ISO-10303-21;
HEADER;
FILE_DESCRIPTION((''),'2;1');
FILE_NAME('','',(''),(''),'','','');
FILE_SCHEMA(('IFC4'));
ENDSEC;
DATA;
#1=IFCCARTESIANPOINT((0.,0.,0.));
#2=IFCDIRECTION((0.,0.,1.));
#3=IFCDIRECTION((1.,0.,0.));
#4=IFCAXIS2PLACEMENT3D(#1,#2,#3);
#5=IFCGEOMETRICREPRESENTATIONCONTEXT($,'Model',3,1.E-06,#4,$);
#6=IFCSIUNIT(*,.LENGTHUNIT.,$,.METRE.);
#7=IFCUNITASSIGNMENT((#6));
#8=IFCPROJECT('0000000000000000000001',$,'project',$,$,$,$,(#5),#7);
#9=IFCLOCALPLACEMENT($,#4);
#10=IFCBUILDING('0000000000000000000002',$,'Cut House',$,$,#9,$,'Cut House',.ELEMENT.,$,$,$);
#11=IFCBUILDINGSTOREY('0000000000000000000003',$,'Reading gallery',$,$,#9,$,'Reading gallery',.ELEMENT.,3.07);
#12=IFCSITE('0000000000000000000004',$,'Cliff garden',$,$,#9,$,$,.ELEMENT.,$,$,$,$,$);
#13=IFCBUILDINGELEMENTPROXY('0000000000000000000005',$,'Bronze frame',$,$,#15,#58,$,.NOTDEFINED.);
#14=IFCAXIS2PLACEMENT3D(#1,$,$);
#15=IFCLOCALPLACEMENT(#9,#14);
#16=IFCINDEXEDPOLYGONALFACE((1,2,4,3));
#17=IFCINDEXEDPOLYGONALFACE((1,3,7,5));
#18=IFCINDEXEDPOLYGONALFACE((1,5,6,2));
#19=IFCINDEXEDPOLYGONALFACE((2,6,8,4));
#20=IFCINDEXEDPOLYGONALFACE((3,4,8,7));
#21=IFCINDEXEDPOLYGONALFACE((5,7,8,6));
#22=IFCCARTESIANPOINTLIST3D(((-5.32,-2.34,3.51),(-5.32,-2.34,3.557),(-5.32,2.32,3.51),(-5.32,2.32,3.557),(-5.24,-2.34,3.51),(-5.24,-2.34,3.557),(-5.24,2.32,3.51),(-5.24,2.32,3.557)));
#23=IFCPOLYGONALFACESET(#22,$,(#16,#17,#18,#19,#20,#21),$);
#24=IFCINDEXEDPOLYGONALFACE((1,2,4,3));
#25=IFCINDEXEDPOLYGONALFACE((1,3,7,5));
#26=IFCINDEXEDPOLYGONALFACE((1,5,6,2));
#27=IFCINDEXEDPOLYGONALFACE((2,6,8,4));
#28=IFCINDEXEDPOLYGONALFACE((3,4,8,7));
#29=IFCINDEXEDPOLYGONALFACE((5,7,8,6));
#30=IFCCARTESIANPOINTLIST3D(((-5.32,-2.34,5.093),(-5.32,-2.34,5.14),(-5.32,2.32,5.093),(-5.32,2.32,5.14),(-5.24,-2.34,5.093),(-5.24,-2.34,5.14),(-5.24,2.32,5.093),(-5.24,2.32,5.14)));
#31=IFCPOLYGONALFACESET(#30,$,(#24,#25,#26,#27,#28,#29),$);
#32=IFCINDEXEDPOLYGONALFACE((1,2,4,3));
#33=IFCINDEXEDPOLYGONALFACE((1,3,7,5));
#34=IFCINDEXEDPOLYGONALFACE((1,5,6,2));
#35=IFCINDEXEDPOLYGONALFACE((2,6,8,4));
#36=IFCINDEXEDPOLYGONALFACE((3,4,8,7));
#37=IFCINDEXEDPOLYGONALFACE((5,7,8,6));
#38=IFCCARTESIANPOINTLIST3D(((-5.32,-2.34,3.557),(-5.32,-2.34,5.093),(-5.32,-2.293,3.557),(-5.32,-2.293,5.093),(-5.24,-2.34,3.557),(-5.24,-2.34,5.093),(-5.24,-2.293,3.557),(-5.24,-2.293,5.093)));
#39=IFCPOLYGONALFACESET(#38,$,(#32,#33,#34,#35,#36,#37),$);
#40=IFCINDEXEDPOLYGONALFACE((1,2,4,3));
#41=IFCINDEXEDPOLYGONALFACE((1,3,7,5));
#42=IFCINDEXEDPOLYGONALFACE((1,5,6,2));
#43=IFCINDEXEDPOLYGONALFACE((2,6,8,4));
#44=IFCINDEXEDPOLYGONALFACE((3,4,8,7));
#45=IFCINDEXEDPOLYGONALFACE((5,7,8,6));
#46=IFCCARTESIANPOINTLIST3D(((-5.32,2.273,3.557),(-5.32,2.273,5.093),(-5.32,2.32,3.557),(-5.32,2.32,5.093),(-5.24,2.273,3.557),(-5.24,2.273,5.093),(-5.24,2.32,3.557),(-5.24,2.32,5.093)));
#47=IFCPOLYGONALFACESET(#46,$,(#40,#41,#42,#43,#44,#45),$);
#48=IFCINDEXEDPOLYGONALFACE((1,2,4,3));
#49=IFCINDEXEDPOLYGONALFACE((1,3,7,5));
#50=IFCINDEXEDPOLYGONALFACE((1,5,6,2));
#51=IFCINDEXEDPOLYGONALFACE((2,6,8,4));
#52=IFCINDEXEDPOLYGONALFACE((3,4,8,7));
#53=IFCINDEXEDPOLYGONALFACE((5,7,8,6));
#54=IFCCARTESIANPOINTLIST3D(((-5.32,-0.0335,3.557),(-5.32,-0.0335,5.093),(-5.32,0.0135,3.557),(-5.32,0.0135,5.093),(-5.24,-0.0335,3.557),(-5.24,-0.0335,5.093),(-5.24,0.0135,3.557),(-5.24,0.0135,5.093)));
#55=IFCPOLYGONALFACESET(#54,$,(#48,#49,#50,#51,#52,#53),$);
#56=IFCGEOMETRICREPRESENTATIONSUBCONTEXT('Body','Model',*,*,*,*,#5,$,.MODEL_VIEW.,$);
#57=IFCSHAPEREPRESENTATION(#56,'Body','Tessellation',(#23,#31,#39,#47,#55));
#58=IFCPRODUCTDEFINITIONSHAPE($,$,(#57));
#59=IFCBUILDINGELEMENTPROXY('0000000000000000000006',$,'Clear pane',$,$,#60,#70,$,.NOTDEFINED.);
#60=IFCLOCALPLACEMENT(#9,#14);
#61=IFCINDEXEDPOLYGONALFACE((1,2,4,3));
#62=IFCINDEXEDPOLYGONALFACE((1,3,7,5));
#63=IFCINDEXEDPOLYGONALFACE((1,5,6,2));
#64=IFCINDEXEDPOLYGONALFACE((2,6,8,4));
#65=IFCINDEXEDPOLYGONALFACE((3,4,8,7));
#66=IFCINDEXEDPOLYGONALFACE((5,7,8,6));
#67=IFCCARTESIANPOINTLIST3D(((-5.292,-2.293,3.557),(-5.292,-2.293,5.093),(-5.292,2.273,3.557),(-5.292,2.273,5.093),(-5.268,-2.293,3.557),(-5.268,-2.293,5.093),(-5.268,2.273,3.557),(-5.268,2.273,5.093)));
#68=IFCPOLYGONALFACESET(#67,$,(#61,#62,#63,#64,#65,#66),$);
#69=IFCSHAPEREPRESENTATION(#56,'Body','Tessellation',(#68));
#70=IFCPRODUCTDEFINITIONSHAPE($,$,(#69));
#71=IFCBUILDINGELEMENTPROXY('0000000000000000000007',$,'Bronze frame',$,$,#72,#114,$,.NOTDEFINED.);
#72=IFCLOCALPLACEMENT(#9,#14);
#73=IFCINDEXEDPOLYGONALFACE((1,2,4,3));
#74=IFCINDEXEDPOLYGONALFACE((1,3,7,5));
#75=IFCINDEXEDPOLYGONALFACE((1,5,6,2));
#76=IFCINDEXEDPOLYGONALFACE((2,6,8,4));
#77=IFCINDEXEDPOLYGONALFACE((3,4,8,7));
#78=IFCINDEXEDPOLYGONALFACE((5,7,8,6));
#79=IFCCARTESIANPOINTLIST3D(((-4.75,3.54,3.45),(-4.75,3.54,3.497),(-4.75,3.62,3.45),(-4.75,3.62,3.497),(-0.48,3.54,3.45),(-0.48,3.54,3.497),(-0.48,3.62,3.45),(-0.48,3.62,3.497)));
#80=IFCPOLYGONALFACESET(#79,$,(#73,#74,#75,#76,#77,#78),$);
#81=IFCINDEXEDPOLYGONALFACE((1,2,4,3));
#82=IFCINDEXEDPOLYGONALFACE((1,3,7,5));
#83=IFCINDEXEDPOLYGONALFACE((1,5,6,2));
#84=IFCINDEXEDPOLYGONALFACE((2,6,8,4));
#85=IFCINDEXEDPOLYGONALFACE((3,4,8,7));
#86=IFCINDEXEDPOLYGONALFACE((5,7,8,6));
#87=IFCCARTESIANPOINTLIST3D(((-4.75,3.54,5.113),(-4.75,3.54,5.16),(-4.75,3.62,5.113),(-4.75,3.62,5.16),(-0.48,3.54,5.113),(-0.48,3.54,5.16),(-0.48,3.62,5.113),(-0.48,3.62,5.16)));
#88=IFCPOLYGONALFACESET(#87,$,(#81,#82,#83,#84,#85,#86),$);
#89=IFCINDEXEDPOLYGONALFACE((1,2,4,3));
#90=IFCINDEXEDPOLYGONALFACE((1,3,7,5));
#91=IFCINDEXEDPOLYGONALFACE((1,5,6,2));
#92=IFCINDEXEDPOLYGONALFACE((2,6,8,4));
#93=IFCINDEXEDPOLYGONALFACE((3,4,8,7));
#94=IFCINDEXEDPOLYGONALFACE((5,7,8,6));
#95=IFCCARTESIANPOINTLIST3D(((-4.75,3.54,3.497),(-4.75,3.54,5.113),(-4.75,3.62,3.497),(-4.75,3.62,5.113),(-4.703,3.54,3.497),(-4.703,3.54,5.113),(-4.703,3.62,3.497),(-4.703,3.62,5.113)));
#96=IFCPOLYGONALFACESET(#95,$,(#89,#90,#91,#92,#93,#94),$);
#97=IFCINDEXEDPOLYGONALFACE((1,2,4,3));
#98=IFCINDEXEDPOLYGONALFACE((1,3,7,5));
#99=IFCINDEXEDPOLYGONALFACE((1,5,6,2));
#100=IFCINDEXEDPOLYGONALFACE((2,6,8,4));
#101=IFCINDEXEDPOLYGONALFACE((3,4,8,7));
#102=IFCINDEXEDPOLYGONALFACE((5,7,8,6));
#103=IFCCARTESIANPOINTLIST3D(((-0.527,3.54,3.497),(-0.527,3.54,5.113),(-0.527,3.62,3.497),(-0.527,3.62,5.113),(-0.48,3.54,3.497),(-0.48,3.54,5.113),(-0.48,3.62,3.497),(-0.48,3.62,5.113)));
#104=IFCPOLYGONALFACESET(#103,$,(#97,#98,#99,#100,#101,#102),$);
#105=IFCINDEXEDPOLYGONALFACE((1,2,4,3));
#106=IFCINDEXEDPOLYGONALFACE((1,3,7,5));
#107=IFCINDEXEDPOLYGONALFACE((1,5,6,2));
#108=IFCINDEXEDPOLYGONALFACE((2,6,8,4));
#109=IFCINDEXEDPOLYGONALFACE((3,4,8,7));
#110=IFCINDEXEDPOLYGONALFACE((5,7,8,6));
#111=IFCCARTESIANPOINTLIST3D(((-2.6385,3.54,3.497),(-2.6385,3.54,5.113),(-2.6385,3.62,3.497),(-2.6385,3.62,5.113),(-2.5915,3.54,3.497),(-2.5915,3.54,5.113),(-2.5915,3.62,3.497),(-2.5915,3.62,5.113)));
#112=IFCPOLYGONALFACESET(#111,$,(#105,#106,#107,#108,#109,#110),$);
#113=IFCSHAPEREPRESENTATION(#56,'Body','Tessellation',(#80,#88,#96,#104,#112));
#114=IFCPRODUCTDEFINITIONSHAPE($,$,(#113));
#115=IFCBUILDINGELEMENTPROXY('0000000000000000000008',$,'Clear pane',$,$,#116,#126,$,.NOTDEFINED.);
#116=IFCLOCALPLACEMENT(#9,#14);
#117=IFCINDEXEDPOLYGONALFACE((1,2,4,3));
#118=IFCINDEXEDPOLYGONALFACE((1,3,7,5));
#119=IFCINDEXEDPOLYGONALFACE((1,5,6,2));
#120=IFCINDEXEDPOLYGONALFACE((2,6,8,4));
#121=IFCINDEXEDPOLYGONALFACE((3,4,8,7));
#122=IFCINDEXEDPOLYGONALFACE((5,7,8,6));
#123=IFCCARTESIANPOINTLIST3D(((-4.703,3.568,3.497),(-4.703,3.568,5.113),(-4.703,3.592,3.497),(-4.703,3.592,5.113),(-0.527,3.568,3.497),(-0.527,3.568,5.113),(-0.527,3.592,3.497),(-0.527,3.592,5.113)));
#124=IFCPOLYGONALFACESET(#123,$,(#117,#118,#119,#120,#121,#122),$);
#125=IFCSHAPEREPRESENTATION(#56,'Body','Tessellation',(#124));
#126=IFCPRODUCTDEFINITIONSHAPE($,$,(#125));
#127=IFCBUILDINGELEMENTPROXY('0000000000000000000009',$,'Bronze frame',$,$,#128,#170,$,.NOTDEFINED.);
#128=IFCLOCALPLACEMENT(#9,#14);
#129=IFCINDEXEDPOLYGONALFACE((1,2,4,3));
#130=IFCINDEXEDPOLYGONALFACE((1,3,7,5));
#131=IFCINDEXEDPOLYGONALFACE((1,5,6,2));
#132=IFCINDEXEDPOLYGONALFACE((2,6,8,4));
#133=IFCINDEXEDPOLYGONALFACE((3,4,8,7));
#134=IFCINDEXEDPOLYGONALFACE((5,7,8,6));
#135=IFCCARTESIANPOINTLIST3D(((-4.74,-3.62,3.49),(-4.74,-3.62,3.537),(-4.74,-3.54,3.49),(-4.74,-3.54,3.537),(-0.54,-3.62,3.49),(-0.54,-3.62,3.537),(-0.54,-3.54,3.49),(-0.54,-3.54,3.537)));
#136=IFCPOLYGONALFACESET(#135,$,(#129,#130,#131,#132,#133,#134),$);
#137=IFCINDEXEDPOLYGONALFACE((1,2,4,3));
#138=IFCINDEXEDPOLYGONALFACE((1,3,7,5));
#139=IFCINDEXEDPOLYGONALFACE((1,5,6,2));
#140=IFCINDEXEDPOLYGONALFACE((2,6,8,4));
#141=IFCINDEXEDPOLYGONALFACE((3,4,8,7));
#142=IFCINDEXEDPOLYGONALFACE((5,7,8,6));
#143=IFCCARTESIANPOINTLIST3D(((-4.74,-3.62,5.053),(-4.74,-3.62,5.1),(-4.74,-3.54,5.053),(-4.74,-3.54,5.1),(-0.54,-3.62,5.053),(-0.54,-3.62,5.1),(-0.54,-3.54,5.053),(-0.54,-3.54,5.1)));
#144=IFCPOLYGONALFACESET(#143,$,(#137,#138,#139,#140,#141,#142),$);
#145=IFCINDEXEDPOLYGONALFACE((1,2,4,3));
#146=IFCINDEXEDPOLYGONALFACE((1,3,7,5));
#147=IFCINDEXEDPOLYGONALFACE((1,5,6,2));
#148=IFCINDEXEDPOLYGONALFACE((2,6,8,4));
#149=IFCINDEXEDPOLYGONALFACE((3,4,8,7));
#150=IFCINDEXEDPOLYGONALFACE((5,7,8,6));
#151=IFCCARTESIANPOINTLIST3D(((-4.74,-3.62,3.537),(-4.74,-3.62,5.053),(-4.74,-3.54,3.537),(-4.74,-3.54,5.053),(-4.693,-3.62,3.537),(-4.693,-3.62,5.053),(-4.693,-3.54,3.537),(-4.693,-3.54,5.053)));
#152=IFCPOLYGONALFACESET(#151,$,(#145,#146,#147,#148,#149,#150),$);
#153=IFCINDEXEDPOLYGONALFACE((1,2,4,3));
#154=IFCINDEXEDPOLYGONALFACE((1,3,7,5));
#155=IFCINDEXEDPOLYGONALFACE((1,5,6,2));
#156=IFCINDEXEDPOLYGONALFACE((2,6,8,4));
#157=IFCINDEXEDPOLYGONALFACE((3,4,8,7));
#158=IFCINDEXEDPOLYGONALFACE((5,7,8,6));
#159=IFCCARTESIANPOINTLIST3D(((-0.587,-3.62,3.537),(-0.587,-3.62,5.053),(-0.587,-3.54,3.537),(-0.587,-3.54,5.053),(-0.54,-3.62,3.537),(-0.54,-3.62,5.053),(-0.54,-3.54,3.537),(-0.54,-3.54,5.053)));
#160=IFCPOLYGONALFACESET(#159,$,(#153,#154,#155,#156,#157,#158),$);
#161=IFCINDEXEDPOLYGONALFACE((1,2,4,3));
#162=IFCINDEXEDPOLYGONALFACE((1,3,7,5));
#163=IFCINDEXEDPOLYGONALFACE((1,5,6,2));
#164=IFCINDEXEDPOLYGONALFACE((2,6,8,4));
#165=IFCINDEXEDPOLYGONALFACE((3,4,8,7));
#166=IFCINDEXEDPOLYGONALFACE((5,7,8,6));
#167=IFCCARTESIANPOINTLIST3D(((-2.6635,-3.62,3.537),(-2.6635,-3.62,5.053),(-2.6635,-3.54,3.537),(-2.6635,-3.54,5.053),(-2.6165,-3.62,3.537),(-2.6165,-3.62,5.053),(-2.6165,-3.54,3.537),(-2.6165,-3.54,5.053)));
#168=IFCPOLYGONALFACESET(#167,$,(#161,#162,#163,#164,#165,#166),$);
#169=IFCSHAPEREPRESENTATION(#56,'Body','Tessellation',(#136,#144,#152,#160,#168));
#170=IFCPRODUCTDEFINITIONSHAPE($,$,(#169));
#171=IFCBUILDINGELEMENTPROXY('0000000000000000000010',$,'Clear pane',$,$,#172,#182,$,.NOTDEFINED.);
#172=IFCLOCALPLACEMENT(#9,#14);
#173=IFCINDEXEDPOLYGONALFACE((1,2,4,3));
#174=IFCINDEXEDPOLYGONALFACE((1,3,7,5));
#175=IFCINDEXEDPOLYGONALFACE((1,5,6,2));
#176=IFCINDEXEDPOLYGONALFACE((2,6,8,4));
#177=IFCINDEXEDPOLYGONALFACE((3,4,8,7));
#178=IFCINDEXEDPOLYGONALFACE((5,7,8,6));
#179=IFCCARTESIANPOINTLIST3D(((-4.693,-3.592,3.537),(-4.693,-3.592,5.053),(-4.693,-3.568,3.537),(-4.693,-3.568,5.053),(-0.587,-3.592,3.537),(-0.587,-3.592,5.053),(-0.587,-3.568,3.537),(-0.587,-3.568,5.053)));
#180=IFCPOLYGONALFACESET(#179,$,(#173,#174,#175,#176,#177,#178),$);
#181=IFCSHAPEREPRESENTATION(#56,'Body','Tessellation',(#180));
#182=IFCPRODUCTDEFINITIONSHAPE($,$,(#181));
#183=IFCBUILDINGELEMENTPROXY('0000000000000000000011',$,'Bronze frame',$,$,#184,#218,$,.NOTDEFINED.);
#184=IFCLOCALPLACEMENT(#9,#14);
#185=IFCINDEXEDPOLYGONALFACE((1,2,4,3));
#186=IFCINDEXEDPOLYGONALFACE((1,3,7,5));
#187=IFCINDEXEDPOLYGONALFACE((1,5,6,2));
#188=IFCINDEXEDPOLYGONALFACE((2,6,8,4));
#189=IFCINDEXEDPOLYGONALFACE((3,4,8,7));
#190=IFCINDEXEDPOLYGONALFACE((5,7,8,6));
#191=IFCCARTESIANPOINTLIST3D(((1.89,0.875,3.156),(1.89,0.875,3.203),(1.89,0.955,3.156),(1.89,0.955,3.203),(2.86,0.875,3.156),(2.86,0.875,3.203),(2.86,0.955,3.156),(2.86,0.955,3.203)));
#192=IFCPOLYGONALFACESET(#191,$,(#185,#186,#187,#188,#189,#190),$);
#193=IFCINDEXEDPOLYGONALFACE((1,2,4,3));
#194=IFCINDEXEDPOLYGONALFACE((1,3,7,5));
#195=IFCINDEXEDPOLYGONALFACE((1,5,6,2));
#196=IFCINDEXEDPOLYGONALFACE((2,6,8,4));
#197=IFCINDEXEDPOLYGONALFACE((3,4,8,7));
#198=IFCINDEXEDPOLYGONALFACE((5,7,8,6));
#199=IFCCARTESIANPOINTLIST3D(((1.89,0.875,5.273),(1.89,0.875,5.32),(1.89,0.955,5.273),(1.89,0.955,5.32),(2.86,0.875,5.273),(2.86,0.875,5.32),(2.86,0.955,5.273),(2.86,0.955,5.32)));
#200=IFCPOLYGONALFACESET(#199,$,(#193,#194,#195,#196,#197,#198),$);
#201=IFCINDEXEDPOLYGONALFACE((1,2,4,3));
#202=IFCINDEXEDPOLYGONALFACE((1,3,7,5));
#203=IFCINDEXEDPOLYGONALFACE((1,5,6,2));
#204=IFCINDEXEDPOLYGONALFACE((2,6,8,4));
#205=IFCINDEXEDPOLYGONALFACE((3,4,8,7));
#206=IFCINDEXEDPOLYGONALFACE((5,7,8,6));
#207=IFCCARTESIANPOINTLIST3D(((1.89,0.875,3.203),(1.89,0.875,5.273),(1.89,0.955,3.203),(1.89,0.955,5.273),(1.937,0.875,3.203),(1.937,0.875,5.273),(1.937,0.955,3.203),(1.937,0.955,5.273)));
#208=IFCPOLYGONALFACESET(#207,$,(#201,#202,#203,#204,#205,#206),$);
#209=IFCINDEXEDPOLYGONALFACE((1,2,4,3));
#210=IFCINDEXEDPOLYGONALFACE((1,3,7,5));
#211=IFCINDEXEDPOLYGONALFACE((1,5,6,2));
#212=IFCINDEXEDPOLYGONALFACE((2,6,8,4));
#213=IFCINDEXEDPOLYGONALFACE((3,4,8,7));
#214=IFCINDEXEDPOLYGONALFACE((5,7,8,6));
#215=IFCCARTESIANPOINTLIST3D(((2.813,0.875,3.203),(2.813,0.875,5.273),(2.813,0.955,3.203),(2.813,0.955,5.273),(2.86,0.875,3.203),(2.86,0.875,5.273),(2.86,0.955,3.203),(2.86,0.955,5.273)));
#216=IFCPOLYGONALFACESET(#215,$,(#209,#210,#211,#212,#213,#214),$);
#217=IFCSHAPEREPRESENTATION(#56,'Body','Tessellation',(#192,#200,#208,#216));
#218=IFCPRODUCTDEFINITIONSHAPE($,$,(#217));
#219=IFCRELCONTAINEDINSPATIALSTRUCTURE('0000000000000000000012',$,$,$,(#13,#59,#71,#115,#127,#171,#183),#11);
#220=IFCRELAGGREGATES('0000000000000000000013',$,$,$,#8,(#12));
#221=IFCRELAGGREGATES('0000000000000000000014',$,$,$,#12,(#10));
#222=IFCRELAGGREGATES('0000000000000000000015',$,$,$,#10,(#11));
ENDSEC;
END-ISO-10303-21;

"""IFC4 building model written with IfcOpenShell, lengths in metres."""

from ifc_helpers import new_model, si_unit, frame, origin_with_axes, place, context, subcontext, project, spatial, polyline, outline, extrude, element, save


model = new_model("IFC4")

# Units and contexts
model_context = context("Model", 3, precision=1e-06, world=origin_with_axes())
body_context = subcontext(model_context, "Body", "Model", "MODEL_VIEW")
ifc_project = project(units=[si_unit("LENGTHUNIT", "METRE")], contexts=[model_context])

# Site, building, storey
placement = place(None, origin_with_axes())
site = spatial("IfcSite", under=ifc_project, at=placement, Name="Cliff garden", CompositionType="ELEMENT")
building = spatial("IfcBuilding", under=site, at=placement, Name="Cut House", LongName="Cut House", CompositionType="ELEMENT")
storey = spatial("IfcBuildingStorey", under=building, at=placement, Name="Reading gallery", LongName="Reading gallery", CompositionType="ELEMENT", Elevation=3.07)

# Building element proxies
element("IfcBuildingElementProxy", 1, at=placement, inside=storey, Name="Bronze frame", PredefinedType="NOTDEFINED", context=body_context, shape_type="SweptSolid", body=[
    extrude(outline(polyline([(0.0, 0.0), (0.08, 0.0), (0.08, 4.66), (0.0, 4.66), (0.0, 0.0)])), frame((-5.32, -2.34, 3.51), z_axis=(0.0, 0.0, 1.0), x_axis=(1.0, 0.0, 0.0)), (0.0, 0.0, 1.0), 0.047),
    extrude(outline(polyline([(0.0, 0.0), (0.08, 0.0), (0.08, 4.66), (0.0, 4.66), (0.0, 0.0)])), frame((-5.32, -2.34, 5.093), z_axis=(0.0, 0.0, 1.0), x_axis=(1.0, 0.0, 0.0)), (0.0, 0.0, 1.0), 0.047),
    extrude(outline(polyline([(0.0, 0.0), (0.08, 0.0), (0.08, 0.047), (0.0, 0.047), (0.0, 0.0)])), frame((-5.32, -2.34, 3.557), z_axis=(0.0, 0.0, 1.0), x_axis=(1.0, 0.0, 0.0)), (0.0, 0.0, 1.0), 1.536),
    extrude(outline(polyline([(0.0, 0.0), (0.08, 0.0), (0.08, 0.047), (0.0, 0.047), (0.0, 0.0)])), frame((-5.32, 2.273, 3.557), z_axis=(0.0, 0.0, 1.0), x_axis=(1.0, 0.0, 0.0)), (0.0, 0.0, 1.0), 1.536),
    extrude(outline(polyline([(0.0, 0.0), (0.08, 0.0), (0.08, 0.047), (0.0, 0.047), (0.0, 0.0)])), frame((-5.32, -0.0335, 3.557), z_axis=(0.0, 0.0, 1.0), x_axis=(1.0, 0.0, 0.0)), (0.0, 0.0, 1.0), 1.536),
])
element("IfcBuildingElementProxy", 2, at=placement, inside=storey, Name="Clear pane", PredefinedType="NOTDEFINED", context=body_context, shape_type="SweptSolid", body=[
    extrude(outline(polyline([(0.0, 0.0), (0.024, 0.0), (0.024, 4.566), (0.0, 4.566), (0.0, 0.0)])), frame((-5.292, -2.293, 3.557), z_axis=(0.0, 0.0, 1.0), x_axis=(1.0, 0.0, 0.0)), (0.0, 0.0, 1.0), 1.536),
])
element("IfcBuildingElementProxy", 3, at=placement, inside=storey, Name="Bronze frame", PredefinedType="NOTDEFINED", context=body_context, shape_type="SweptSolid", body=[
    extrude(outline(polyline([(0.0, 0.0), (4.27, 0.0), (4.27, 0.08), (0.0, 0.08), (0.0, 0.0)])), frame((-4.75, 3.54, 3.45), z_axis=(0.0, 0.0, 1.0), x_axis=(1.0, 0.0, 0.0)), (0.0, 0.0, 1.0), 0.047),
    extrude(outline(polyline([(0.0, 0.0), (4.27, 0.0), (4.27, 0.08), (0.0, 0.08), (0.0, 0.0)])), frame((-4.75, 3.54, 5.113), z_axis=(0.0, 0.0, 1.0), x_axis=(1.0, 0.0, 0.0)), (0.0, 0.0, 1.0), 0.047),
    extrude(outline(polyline([(0.0, 0.0), (0.047, 0.0), (0.047, 0.08), (0.0, 0.08), (0.0, 0.0)])), frame((-4.75, 3.54, 3.497), z_axis=(0.0, 0.0, 1.0), x_axis=(1.0, 0.0, 0.0)), (0.0, 0.0, 1.0), 1.616),
    extrude(outline(polyline([(0.0, 0.0), (0.047, 0.0), (0.047, 0.08), (0.0, 0.08), (0.0, 0.0)])), frame((-0.527, 3.54, 3.497), z_axis=(0.0, 0.0, 1.0), x_axis=(1.0, 0.0, 0.0)), (0.0, 0.0, 1.0), 1.616),
    extrude(outline(polyline([(0.0, 0.0), (0.047, 0.0), (0.047, 0.08), (0.0, 0.08), (0.0, 0.0)])), frame((-2.6385, 3.54, 3.497), z_axis=(0.0, 0.0, 1.0), x_axis=(1.0, 0.0, 0.0)), (0.0, 0.0, 1.0), 1.616),
])
element("IfcBuildingElementProxy", 4, at=placement, inside=storey, Name="Clear pane", PredefinedType="NOTDEFINED", context=body_context, shape_type="SweptSolid", body=[
    extrude(outline(polyline([(0.0, 0.0), (4.176, 0.0), (4.176, 0.024), (0.0, 0.024), (0.0, 0.0)])), frame((-4.703, 3.568, 3.497), z_axis=(0.0, 0.0, 1.0), x_axis=(1.0, 0.0, 0.0)), (0.0, 0.0, 1.0), 1.616),
])
element("IfcBuildingElementProxy", 5, at=placement, inside=storey, Name="Bronze frame", PredefinedType="NOTDEFINED", context=body_context, shape_type="SweptSolid", body=[
    extrude(outline(polyline([(0.0, 0.0), (4.2, 0.0), (4.2, 0.08), (0.0, 0.08), (0.0, 0.0)])), frame((-4.74, -3.62, 3.49), z_axis=(0.0, 0.0, 1.0), x_axis=(1.0, 0.0, 0.0)), (0.0, 0.0, 1.0), 0.047),
    extrude(outline(polyline([(0.0, 0.0), (4.2, 0.0), (4.2, 0.08), (0.0, 0.08), (0.0, 0.0)])), frame((-4.74, -3.62, 5.053), z_axis=(0.0, 0.0, 1.0), x_axis=(1.0, 0.0, 0.0)), (0.0, 0.0, 1.0), 0.047),
    extrude(outline(polyline([(0.0, 0.0), (0.047, 0.0), (0.047, 0.08), (0.0, 0.08), (0.0, 0.0)])), frame((-4.74, -3.62, 3.537), z_axis=(0.0, 0.0, 1.0), x_axis=(1.0, 0.0, 0.0)), (0.0, 0.0, 1.0), 1.516),
    extrude(outline(polyline([(0.0, 0.0), (0.047, 0.0), (0.047, 0.08), (0.0, 0.08), (0.0, 0.0)])), frame((-0.587, -3.62, 3.537), z_axis=(0.0, 0.0, 1.0), x_axis=(1.0, 0.0, 0.0)), (0.0, 0.0, 1.0), 1.516),
    extrude(outline(polyline([(0.0, 0.0), (0.047, 0.0), (0.047, 0.08), (0.0, 0.08), (0.0, 0.0)])), frame((-2.6635, -3.62, 3.537), z_axis=(0.0, 0.0, 1.0), x_axis=(1.0, 0.0, 0.0)), (0.0, 0.0, 1.0), 1.516),
])
element("IfcBuildingElementProxy", 6, at=placement, inside=storey, Name="Clear pane", PredefinedType="NOTDEFINED", context=body_context, shape_type="SweptSolid", body=[
    extrude(outline(polyline([(0.0, 0.0), (4.106, 0.0), (4.106, 0.024), (0.0, 0.024), (0.0, 0.0)])), frame((-4.693, -3.592, 3.537), z_axis=(0.0, 0.0, 1.0), x_axis=(1.0, 0.0, 0.0)), (0.0, 0.0, 1.0), 1.516),
])
element("IfcBuildingElementProxy", 7, at=placement, inside=storey, Name="Bronze frame", PredefinedType="NOTDEFINED", context=body_context, shape_type="SweptSolid", body=[
    extrude(outline(polyline([(0.0, 0.0), (0.97, 0.0), (0.97, 0.08), (0.0, 0.08), (0.0, 0.0)])), frame((1.89, 0.875, 3.156), z_axis=(0.0, 0.0, 1.0), x_axis=(1.0, 0.0, 0.0)), (0.0, 0.0, 1.0), 0.047),
    extrude(outline(polyline([(0.0, 0.0), (0.97, 0.0), (0.97, 0.08), (0.0, 0.08), (0.0, 0.0)])), frame((1.89, 0.875, 5.273), z_axis=(0.0, 0.0, 1.0), x_axis=(1.0, 0.0, 0.0)), (0.0, 0.0, 1.0), 0.047),
    extrude(outline(polyline([(0.0, 0.0), (0.047, 0.0), (0.047, 0.08), (0.0, 0.08), (0.0, 0.0)])), frame((1.89, 0.875, 3.203), z_axis=(0.0, 0.0, 1.0), x_axis=(1.0, 0.0, 0.0)), (0.0, 0.0, 1.0), 2.07),
    extrude(outline(polyline([(0.0, 0.0), (0.047, 0.0), (0.047, 0.08), (0.0, 0.08), (0.0, 0.0)])), frame((2.813, 0.875, 3.203), z_axis=(0.0, 0.0, 1.0), x_axis=(1.0, 0.0, 0.0)), (0.0, 0.0, 1.0), 2.07),
])

save(model, "model.ifc")
